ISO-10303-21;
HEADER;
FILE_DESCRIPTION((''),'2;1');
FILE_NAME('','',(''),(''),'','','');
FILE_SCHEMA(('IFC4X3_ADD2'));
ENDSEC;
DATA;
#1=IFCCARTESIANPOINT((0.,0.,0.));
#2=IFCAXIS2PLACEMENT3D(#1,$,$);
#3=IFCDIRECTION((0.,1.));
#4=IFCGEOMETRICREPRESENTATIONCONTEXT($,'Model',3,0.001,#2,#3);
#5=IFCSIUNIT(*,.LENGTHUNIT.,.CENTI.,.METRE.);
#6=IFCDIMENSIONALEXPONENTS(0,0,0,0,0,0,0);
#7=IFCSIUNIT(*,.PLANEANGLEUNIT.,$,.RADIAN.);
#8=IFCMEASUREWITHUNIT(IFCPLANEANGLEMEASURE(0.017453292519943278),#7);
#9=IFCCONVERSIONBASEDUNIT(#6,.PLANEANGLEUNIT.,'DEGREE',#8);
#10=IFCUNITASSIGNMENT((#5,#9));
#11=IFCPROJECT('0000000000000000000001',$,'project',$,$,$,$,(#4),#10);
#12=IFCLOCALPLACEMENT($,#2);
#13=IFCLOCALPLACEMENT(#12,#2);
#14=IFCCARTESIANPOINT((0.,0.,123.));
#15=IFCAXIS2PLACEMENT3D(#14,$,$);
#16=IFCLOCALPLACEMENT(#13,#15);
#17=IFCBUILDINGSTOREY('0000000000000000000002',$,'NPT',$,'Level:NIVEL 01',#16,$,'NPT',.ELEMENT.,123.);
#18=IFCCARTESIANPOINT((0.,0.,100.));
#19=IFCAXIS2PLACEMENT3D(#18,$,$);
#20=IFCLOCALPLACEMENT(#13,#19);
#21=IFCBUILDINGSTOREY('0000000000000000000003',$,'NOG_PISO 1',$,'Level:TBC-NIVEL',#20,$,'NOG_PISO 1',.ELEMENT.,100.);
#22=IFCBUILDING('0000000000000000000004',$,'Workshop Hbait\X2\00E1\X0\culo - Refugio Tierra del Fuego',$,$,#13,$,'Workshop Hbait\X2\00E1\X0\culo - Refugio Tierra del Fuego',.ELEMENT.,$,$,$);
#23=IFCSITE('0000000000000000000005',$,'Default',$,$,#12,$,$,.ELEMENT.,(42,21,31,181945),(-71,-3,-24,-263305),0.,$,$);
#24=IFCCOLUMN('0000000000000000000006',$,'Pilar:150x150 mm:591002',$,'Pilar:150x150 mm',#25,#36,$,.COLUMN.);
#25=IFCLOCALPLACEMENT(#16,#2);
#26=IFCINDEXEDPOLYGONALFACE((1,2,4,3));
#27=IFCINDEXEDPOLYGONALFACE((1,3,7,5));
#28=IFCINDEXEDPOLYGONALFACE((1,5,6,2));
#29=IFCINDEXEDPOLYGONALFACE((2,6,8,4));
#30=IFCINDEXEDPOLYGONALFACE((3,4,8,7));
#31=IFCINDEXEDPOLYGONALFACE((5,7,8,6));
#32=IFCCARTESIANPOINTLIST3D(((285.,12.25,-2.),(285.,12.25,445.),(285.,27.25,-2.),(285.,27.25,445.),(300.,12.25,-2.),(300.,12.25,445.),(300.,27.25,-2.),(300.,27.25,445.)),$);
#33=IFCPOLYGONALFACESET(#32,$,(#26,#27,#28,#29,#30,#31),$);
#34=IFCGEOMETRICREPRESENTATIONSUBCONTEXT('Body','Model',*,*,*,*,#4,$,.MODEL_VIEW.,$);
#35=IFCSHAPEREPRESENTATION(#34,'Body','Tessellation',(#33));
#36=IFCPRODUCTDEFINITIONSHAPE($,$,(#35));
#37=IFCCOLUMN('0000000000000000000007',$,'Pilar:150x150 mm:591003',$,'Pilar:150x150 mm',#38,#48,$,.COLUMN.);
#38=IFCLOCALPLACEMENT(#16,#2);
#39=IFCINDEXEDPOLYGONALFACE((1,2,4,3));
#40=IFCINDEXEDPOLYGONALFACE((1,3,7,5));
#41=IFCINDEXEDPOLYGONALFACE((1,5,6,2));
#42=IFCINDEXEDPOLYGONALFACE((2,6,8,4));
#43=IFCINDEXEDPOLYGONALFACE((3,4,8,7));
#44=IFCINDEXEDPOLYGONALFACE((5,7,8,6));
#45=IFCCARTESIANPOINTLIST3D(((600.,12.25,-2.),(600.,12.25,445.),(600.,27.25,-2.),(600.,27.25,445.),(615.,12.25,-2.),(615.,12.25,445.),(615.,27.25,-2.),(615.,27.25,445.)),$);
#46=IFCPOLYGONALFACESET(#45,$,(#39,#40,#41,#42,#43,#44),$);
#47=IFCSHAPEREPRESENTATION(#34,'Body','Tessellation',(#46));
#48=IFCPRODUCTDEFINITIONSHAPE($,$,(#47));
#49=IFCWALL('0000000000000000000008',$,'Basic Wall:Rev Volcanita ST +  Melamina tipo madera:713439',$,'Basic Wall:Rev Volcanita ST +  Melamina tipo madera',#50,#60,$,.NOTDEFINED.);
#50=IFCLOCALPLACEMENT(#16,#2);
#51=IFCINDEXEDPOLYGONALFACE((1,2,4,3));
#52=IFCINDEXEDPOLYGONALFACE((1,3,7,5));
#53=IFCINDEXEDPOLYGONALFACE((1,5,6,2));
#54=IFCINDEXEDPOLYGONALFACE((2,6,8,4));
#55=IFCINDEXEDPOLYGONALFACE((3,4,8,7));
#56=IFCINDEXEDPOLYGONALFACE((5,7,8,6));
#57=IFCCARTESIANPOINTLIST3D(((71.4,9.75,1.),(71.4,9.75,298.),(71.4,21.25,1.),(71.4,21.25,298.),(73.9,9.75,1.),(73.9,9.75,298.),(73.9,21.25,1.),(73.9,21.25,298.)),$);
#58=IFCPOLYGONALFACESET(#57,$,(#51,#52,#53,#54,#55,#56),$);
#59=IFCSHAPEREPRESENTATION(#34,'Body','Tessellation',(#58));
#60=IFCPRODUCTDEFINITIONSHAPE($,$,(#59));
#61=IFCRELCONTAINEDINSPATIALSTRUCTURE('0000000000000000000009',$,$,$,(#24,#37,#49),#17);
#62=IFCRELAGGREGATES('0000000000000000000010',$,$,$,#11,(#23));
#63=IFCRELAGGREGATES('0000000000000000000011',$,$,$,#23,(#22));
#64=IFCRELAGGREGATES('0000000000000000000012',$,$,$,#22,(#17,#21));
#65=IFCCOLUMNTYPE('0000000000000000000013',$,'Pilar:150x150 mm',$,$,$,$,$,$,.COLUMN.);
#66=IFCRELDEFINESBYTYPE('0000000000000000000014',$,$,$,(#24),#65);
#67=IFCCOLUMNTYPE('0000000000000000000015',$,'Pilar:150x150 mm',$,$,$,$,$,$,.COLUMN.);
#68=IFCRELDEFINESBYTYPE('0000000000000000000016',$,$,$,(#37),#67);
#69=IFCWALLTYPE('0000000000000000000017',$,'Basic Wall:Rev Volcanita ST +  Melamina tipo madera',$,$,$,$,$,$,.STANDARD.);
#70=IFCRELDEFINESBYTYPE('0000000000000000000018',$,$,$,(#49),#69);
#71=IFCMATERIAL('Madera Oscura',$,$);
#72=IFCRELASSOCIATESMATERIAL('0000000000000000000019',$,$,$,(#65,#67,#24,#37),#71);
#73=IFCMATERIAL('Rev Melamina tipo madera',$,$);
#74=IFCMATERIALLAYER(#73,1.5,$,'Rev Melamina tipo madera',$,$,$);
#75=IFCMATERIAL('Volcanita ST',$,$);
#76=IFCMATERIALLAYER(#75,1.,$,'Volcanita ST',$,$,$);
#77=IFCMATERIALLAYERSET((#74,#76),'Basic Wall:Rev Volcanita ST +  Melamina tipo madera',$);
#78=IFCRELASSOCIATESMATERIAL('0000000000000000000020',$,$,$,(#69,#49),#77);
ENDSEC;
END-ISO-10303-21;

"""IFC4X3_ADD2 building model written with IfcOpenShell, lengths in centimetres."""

from ifc_helpers import new_model, entity, si_unit, converted_unit, direction, frame, frame_2d, origin, origin_2d_with_axis, place, context, subcontext, project, spatial, rectangle, extrude, source, transform, mapped, material, layer, layer_set, material_profile, profile_set, profile_usage, type_object, type_shapes, element, save


model = new_model("IFC4X3_ADD2")

# Units and contexts
model_context = context("Model", 3, precision=0.001, world=origin(), true_north=direction((0.0, 1.0)))
body_context = subcontext(model_context, "Body", "Model", "MODEL_VIEW")
ifc_project = project(units=[si_unit("LENGTHUNIT", "METRE", prefix="CENTI"), converted_unit("PLANEANGLEUNIT", "DEGREE", entity("IfcPlaneAngleMeasure", 0.017453292519943278), si_unit("PLANEANGLEUNIT", "RADIAN"), dimensions=[0, 0, 0, 0, 0, 0, 0])], contexts=[model_context])

# Site, building, storey
site_placement = place(None, origin())
site = spatial("IfcSite", under=ifc_project, at=site_placement, Name="Default", CompositionType="ELEMENT", RefLatitude=(42, 21, 31, 181945), RefLongitude=(-71, -3, -24, -263305), RefElevation=0.0)
building_placement = place(site_placement, origin())
building = spatial("IfcBuilding", under=site, at=building_placement, Name="Workshop Hbaitáculo - Refugio Tierra del Fuego", LongName="Workshop Hbaitáculo - Refugio Tierra del Fuego", CompositionType="ELEMENT")
storey_1_placement = place(building_placement, frame((0.0, 0.0, 123.0)))
storey_1 = spatial("IfcBuildingStorey", under=building, at=storey_1_placement, Name="NPT", ObjectType="Level:NIVEL 01", LongName="NPT", CompositionType="ELEMENT", Elevation=123.0)

# Columns
ifc_material_1 = material(Name="Madera Oscura")
ifc_material_profile = material_profile(ifc_material_1, rectangle(XDim=15.0, YDim=15.0, at=origin_2d_with_axis()), Name="150x150 mm")
ifc_profile_set = profile_set([ifc_material_profile], Name="150x150 mm")
ifc_profile_usage = profile_usage(ifc_profile_set)
column_type_1 = type_object("IfcColumnType", Name="Pilar:150x150 mm", PredefinedType="COLUMN", material=ifc_profile_set)
shared_shape_1 = source(origin(), body_context, "Body", "SweptSolid", [
    extrude(rectangle(XDim=15.0, YDim=15.0, at=origin_2d_with_axis()), frame((7.5, 7.5, 0.0), z_axis=(0.0, 0.0, 1.0), x_axis=(-1.0, 0.0, 0.0)), (0.0, 0.0, 1.0), 447.0),
])
type_shapes(column_type_1, [shared_shape_1])
column_1_placement = place(storey_1_placement, frame((285.0, 12.25, -2.0)))
element("IfcColumn", 1, at=column_1_placement, inside=storey_1, type_object=column_type_1, material=ifc_profile_usage, Name="Pilar:150x150 mm:591002", ObjectType="Pilar:150x150 mm", PredefinedType="COLUMN", context=body_context, shape_type="MappedRepresentation", body=[
    mapped(shared_shape_1, transform((0.0, 0.0, 0.0), scale=1.0)),
])
column_type_2 = type_object("IfcColumnType", Name="Pilar:150x150 mm", PredefinedType="COLUMN", material=ifc_profile_set)
shared_shape_2 = source(origin(), body_context, "Body", "SweptSolid", [
    extrude(rectangle(XDim=15.0, YDim=15.0, at=origin_2d_with_axis()), frame((7.5, 7.5, 0.0), z_axis=(0.0, 0.0, 1.0), x_axis=(0.0, 1.0, 0.0)), (0.0, 0.0, 1.0), 447.0),
])
type_shapes(column_type_2, [shared_shape_2])
column_2_placement = place(storey_1_placement, frame((615.0, 27.25, -2.0), z_axis=(0.0, 0.0, 1.0), x_axis=(-1.0, 0.0, 0.0)))
element("IfcColumn", 2, at=column_2_placement, inside=storey_1, type_object=column_type_2, material=ifc_profile_usage, Name="Pilar:150x150 mm:591003", ObjectType="Pilar:150x150 mm", PredefinedType="COLUMN", context=body_context, shape_type="MappedRepresentation", body=[
    mapped(shared_shape_2, transform((0.0, 0.0, 0.0), scale=1.0)),
])

# Shared definitions
storey_2_placement = place(building_placement, frame((0.0, 0.0, 100.0)))
storey_2 = spatial("IfcBuildingStorey", under=building, at=storey_2_placement, Name="NOG_PISO 1", ObjectType="Level:TBC-NIVEL", LongName="NOG_PISO 1", CompositionType="ELEMENT", Elevation=100.0)

# Wall
ifc_material_2 = material(Name="Rev Melamina tipo madera")
ifc_layer_1 = layer(ifc_material_2, 1.5, Name="Rev Melamina tipo madera")
ifc_material_3 = material(Name="Volcanita ST")
ifc_layer_2 = layer(ifc_material_3, 1.0, Name="Volcanita ST")
ifc_layer_set_1 = layer_set([ifc_layer_1, ifc_layer_2], Name="Basic Wall:Rev Volcanita ST +  Melamina tipo madera")
wall_type_1 = type_object("IfcWallType", Name="Basic Wall:Rev Volcanita ST +  Melamina tipo madera", PredefinedType="STANDARD", material=ifc_layer_set_1)
wall_1_placement = place(storey_1_placement, frame((72.65, 21.25, 1.0), z_axis=(0.0, 0.0, 1.0), x_axis=(0.0, -1.0, 0.0)))
element("IfcWall", 3, at=wall_1_placement, inside=storey_1, type_object=wall_type_1, material=ifc_layer_set_1, Name="Basic Wall:Rev Volcanita ST +  Melamina tipo madera:713439", ObjectType="Basic Wall:Rev Volcanita ST +  Melamina tipo madera", PredefinedType="NOTDEFINED", context=body_context, shape_type="SweptSolid", body=[
    extrude(rectangle(XDim=11.5, YDim=2.5, at=frame_2d((5.75, 0.0), x_axis=(-1.0, 0.0))), origin(), (0.0, 0.0, 1.0), 297.0),
])

save(model, "model.ifc")
